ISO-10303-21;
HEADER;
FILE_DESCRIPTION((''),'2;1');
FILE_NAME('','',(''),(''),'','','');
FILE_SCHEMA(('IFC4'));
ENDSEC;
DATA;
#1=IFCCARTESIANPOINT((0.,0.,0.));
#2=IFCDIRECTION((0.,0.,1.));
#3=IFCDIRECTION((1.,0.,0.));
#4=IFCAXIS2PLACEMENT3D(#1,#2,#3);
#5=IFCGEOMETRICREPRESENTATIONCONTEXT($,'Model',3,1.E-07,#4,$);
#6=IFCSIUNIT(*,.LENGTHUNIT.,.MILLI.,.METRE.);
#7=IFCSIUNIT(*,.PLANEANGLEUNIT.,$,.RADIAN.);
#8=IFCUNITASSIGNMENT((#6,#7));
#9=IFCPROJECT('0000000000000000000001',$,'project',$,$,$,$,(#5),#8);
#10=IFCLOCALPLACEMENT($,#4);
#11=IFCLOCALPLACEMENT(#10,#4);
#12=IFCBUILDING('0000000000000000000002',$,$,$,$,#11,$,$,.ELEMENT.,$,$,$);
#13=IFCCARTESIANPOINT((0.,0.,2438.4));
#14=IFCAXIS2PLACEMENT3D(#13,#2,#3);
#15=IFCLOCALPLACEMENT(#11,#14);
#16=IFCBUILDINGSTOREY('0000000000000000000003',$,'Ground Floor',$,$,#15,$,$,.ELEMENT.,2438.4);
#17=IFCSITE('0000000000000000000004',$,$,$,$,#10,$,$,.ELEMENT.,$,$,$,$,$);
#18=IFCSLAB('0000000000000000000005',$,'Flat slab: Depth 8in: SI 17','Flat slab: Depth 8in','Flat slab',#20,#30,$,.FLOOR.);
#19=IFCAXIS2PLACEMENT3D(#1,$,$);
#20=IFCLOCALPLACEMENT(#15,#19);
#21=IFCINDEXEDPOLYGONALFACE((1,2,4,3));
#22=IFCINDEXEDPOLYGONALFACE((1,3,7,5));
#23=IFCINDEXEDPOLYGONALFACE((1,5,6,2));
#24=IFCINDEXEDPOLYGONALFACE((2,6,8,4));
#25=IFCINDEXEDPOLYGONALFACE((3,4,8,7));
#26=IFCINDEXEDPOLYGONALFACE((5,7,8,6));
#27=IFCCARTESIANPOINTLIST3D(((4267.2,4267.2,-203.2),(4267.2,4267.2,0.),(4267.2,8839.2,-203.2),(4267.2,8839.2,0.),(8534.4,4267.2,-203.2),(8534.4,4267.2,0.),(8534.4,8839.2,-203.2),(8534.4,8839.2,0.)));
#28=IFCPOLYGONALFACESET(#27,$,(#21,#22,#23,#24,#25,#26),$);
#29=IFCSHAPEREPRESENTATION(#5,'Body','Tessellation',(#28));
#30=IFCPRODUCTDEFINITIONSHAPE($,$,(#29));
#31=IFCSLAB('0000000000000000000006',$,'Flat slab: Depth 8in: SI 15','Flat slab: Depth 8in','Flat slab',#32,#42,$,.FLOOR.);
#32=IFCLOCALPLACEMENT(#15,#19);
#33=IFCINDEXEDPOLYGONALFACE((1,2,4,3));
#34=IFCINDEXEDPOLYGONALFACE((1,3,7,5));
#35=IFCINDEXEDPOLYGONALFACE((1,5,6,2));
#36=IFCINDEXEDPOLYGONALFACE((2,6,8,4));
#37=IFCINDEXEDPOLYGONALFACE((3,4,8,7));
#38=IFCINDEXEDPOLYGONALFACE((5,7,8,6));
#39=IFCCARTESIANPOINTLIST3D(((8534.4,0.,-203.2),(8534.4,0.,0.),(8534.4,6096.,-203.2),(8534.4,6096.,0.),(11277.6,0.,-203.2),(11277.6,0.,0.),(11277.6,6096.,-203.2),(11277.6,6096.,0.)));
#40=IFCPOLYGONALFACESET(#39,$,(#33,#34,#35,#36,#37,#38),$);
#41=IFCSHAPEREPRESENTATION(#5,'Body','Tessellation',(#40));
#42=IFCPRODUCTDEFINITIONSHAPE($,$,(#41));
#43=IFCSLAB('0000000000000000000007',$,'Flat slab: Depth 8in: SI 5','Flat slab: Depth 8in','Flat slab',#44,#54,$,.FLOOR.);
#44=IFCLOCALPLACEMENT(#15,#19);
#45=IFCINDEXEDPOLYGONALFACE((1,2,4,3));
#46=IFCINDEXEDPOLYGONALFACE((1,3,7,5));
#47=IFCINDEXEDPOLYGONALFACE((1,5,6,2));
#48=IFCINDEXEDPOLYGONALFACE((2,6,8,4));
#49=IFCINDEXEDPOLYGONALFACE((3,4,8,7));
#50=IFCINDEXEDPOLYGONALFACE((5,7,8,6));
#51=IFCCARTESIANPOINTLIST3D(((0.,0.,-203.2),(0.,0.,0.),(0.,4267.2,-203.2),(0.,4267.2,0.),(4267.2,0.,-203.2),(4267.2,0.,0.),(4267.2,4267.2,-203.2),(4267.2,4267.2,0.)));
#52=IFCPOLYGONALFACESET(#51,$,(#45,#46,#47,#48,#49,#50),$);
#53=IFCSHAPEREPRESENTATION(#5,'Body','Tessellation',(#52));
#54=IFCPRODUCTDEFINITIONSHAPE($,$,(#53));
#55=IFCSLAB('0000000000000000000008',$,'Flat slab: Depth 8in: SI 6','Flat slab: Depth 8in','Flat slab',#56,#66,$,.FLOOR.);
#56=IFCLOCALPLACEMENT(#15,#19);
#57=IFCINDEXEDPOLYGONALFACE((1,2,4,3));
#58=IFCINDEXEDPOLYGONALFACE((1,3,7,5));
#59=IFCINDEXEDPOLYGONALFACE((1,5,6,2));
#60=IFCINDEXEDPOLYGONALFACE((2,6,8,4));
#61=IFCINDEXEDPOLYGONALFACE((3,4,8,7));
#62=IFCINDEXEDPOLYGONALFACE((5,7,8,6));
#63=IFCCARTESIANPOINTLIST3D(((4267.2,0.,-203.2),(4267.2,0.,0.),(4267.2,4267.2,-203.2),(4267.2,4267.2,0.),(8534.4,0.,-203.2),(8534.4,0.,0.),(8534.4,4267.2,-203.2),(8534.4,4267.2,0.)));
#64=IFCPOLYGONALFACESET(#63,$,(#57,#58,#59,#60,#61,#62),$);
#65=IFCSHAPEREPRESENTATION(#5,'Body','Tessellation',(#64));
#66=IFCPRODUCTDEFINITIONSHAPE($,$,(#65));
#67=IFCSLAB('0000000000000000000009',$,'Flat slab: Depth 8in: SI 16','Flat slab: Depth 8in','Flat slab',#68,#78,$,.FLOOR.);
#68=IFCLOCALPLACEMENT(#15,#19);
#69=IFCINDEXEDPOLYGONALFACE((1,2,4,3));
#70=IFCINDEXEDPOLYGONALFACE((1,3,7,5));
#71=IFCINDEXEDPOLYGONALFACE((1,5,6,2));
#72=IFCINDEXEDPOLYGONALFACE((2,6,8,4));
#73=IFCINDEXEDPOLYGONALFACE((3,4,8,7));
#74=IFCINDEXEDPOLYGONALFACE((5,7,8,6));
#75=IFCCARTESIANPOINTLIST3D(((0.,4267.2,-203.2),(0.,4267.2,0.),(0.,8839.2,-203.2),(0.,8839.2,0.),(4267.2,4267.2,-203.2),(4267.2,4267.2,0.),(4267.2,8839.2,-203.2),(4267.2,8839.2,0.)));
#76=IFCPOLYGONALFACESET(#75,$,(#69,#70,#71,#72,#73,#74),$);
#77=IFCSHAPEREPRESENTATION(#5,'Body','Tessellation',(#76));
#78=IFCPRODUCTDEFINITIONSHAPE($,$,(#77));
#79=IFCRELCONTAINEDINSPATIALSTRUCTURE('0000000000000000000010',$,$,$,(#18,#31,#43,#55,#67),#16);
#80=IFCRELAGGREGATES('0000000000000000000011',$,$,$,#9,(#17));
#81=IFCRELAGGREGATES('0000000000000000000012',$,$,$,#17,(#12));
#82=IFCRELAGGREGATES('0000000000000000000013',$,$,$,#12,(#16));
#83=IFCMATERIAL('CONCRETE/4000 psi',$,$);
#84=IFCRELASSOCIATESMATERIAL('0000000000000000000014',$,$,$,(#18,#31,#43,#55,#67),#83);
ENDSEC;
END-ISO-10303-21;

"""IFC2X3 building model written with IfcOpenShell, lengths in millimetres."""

from ifc_helpers import new_model, si_unit, frame, origin_with_axes, place, context, project, spatial, polyline, segment, composite_curve, outline, extrude, material, element, save


model = new_model("IFC2X3")

# Units and contexts
model_context = context("Model", 3, precision=1e-07, world=origin_with_axes())
ifc_project = project(units=[si_unit("LENGTHUNIT", "METRE", prefix="MILLI"), si_unit("PLANEANGLEUNIT", "RADIAN")], contexts=[model_context])

# Site, building, storey
site_placement = place(None, origin_with_axes())
site = spatial("IfcSite", under=ifc_project, at=site_placement, CompositionType="ELEMENT")
building_placement = place(site_placement, origin_with_axes())
building = spatial("IfcBuilding", under=site, at=building_placement, CompositionType="ELEMENT")
storey_placement = place(building_placement, frame((0.0, 0.0, 2438.4), z_axis=(0.0, 0.0, 1.0), x_axis=(1.0, 0.0, 0.0)))
storey = spatial("IfcBuildingStorey", under=building, at=storey_placement, Name="Ground Floor", CompositionType="ELEMENT", Elevation=2438.4)

# Shared definitions
ifc_material = material(Name="CONCRETE/4000 psi")

# Slabs
slab_1_placement = place(building_placement, frame((0.0, 0.0, 2438.4), z_axis=(0.0, 0.0, 1.0), x_axis=(1.0, 0.0, 0.0)))
element("IfcSlab", 1, at=slab_1_placement, inside=storey, material=ifc_material, Name="Flat slab: Depth 8in: SI 17", Description="Flat slab: Depth 8in", ObjectType="Flat slab", PredefinedType="FLOOR", context=model_context, shape_type="SweptSolid", body=[
    extrude(outline(composite_curve([segment(polyline([(4267.2, 8839.2), (4267.2, 4267.2)]), True, "CONTINUOUS"), segment(polyline([(4267.2, 4267.2), (8534.4, 4267.2)]), True, "CONTINUOUS"), segment(polyline([(8534.4, 4267.2), (8534.4, 8839.2)]), True, "CONTINUOUS"), segment(polyline([(8534.4, 8839.2), (4267.2, 8839.2)]), True, "CONTINUOUS")], self_intersect=False)), frame((0.0, 0.0, -203.2), z_axis=(0.0, 0.0, 1.0), x_axis=(1.0, 0.0, 0.0)), (0.0, 0.0, 1.0), 203.2),
])
slab_2_placement = place(building_placement, frame((0.0, 0.0, 2438.4), z_axis=(0.0, 0.0, 1.0), x_axis=(1.0, 0.0, 0.0)))
element("IfcSlab", 2, at=slab_2_placement, inside=storey, material=ifc_material, Name="Flat slab: Depth 8in: SI 15", Description="Flat slab: Depth 8in", ObjectType="Flat slab", PredefinedType="FLOOR", context=model_context, shape_type="SweptSolid", body=[
    extrude(outline(composite_curve([segment(polyline([(8534.4, 6096.0), (8534.4, 0.0)]), True, "CONTINUOUS"), segment(polyline([(8534.4, 0.0), (11277.6, 0.0)]), True, "CONTINUOUS"), segment(polyline([(11277.6, 0.0), (11277.6, 6096.0)]), True, "CONTINUOUS"), segment(polyline([(11277.6, 6096.0), (8534.4, 6096.0)]), True, "CONTINUOUS")], self_intersect=False)), frame((0.0, 0.0, -203.2), z_axis=(0.0, 0.0, 1.0), x_axis=(1.0, 0.0, 0.0)), (0.0, 0.0, 1.0), 203.2),
])
slab_3_placement = place(building_placement, frame((0.0, 0.0, 2438.4), z_axis=(0.0, 0.0, 1.0), x_axis=(1.0, 0.0, 0.0)))
element("IfcSlab", 3, at=slab_3_placement, inside=storey, material=ifc_material, Name="Flat slab: Depth 8in: SI 5", Description="Flat slab: Depth 8in", ObjectType="Flat slab", PredefinedType="FLOOR", context=model_context, shape_type="SweptSolid", body=[
    extrude(outline(composite_curve([segment(polyline([(4267.2, 4267.2), (0.0, 4267.2)]), True, "CONTINUOUS"), segment(polyline([(0.0, 4267.2), (0.0, 0.0)]), True, "CONTINUOUS"), segment(polyline([(0.0, 0.0), (4267.2, 0.0)]), True, "CONTINUOUS"), segment(polyline([(4267.2, 0.0), (4267.2, 4267.2)]), True, "CONTINUOUS")], self_intersect=False)), frame((0.0, 0.0, -203.2), z_axis=(0.0, 0.0, 1.0), x_axis=(1.0, 0.0, 0.0)), (0.0, 0.0, 1.0), 203.2),
])
slab_4_placement = place(building_placement, frame((0.0, 0.0, 2438.4), z_axis=(0.0, 0.0, 1.0), x_axis=(1.0, 0.0, 0.0)))
element("IfcSlab", 4, at=slab_4_placement, inside=storey, material=ifc_material, Name="Flat slab: Depth 8in: SI 6", Description="Flat slab: Depth 8in", ObjectType="Flat slab", PredefinedType="FLOOR", context=model_context, shape_type="SweptSolid", body=[
    extrude(outline(composite_curve([segment(polyline([(8534.4, 4267.2), (4267.2, 4267.2)]), True, "CONTINUOUS"), segment(polyline([(4267.2, 4267.2), (4267.2, 0.0)]), True, "CONTINUOUS"), segment(polyline([(4267.2, 0.0), (8534.4, 0.0)]), True, "CONTINUOUS"), segment(polyline([(8534.4, 0.0), (8534.4, 4267.2)]), True, "CONTINUOUS")], self_intersect=False)), frame((0.0, 0.0, -203.2), z_axis=(0.0, 0.0, 1.0), x_axis=(1.0, 0.0, 0.0)), (0.0, 0.0, 1.0), 203.2),
])
slab_5_placement = place(building_placement, frame((0.0, 0.0, 2438.4), z_axis=(0.0, 0.0, 1.0), x_axis=(1.0, 0.0, 0.0)))
element("IfcSlab", 5, at=slab_5_placement, inside=storey, material=ifc_material, Name="Flat slab: Depth 8in: SI 16", Description="Flat slab: Depth 8in", ObjectType="Flat slab", PredefinedType="FLOOR", context=model_context, shape_type="SweptSolid", body=[
    extrude(outline(composite_curve([segment(polyline([(0.0, 8839.2), (0.0, 4267.2)]), True, "CONTINUOUS"), segment(polyline([(0.0, 4267.2), (4267.2, 4267.2)]), True, "CONTINUOUS"), segment(polyline([(4267.2, 4267.2), (4267.2, 8839.2)]), True, "CONTINUOUS"), segment(polyline([(4267.2, 8839.2), (0.0, 8839.2)]), True, "CONTINUOUS")], self_intersect=False)), frame((0.0, 0.0, -203.2), z_axis=(0.0, 0.0, 1.0), x_axis=(1.0, 0.0, 0.0)), (0.0, 0.0, 1.0), 203.2),
])

save(model, "model.ifc")
